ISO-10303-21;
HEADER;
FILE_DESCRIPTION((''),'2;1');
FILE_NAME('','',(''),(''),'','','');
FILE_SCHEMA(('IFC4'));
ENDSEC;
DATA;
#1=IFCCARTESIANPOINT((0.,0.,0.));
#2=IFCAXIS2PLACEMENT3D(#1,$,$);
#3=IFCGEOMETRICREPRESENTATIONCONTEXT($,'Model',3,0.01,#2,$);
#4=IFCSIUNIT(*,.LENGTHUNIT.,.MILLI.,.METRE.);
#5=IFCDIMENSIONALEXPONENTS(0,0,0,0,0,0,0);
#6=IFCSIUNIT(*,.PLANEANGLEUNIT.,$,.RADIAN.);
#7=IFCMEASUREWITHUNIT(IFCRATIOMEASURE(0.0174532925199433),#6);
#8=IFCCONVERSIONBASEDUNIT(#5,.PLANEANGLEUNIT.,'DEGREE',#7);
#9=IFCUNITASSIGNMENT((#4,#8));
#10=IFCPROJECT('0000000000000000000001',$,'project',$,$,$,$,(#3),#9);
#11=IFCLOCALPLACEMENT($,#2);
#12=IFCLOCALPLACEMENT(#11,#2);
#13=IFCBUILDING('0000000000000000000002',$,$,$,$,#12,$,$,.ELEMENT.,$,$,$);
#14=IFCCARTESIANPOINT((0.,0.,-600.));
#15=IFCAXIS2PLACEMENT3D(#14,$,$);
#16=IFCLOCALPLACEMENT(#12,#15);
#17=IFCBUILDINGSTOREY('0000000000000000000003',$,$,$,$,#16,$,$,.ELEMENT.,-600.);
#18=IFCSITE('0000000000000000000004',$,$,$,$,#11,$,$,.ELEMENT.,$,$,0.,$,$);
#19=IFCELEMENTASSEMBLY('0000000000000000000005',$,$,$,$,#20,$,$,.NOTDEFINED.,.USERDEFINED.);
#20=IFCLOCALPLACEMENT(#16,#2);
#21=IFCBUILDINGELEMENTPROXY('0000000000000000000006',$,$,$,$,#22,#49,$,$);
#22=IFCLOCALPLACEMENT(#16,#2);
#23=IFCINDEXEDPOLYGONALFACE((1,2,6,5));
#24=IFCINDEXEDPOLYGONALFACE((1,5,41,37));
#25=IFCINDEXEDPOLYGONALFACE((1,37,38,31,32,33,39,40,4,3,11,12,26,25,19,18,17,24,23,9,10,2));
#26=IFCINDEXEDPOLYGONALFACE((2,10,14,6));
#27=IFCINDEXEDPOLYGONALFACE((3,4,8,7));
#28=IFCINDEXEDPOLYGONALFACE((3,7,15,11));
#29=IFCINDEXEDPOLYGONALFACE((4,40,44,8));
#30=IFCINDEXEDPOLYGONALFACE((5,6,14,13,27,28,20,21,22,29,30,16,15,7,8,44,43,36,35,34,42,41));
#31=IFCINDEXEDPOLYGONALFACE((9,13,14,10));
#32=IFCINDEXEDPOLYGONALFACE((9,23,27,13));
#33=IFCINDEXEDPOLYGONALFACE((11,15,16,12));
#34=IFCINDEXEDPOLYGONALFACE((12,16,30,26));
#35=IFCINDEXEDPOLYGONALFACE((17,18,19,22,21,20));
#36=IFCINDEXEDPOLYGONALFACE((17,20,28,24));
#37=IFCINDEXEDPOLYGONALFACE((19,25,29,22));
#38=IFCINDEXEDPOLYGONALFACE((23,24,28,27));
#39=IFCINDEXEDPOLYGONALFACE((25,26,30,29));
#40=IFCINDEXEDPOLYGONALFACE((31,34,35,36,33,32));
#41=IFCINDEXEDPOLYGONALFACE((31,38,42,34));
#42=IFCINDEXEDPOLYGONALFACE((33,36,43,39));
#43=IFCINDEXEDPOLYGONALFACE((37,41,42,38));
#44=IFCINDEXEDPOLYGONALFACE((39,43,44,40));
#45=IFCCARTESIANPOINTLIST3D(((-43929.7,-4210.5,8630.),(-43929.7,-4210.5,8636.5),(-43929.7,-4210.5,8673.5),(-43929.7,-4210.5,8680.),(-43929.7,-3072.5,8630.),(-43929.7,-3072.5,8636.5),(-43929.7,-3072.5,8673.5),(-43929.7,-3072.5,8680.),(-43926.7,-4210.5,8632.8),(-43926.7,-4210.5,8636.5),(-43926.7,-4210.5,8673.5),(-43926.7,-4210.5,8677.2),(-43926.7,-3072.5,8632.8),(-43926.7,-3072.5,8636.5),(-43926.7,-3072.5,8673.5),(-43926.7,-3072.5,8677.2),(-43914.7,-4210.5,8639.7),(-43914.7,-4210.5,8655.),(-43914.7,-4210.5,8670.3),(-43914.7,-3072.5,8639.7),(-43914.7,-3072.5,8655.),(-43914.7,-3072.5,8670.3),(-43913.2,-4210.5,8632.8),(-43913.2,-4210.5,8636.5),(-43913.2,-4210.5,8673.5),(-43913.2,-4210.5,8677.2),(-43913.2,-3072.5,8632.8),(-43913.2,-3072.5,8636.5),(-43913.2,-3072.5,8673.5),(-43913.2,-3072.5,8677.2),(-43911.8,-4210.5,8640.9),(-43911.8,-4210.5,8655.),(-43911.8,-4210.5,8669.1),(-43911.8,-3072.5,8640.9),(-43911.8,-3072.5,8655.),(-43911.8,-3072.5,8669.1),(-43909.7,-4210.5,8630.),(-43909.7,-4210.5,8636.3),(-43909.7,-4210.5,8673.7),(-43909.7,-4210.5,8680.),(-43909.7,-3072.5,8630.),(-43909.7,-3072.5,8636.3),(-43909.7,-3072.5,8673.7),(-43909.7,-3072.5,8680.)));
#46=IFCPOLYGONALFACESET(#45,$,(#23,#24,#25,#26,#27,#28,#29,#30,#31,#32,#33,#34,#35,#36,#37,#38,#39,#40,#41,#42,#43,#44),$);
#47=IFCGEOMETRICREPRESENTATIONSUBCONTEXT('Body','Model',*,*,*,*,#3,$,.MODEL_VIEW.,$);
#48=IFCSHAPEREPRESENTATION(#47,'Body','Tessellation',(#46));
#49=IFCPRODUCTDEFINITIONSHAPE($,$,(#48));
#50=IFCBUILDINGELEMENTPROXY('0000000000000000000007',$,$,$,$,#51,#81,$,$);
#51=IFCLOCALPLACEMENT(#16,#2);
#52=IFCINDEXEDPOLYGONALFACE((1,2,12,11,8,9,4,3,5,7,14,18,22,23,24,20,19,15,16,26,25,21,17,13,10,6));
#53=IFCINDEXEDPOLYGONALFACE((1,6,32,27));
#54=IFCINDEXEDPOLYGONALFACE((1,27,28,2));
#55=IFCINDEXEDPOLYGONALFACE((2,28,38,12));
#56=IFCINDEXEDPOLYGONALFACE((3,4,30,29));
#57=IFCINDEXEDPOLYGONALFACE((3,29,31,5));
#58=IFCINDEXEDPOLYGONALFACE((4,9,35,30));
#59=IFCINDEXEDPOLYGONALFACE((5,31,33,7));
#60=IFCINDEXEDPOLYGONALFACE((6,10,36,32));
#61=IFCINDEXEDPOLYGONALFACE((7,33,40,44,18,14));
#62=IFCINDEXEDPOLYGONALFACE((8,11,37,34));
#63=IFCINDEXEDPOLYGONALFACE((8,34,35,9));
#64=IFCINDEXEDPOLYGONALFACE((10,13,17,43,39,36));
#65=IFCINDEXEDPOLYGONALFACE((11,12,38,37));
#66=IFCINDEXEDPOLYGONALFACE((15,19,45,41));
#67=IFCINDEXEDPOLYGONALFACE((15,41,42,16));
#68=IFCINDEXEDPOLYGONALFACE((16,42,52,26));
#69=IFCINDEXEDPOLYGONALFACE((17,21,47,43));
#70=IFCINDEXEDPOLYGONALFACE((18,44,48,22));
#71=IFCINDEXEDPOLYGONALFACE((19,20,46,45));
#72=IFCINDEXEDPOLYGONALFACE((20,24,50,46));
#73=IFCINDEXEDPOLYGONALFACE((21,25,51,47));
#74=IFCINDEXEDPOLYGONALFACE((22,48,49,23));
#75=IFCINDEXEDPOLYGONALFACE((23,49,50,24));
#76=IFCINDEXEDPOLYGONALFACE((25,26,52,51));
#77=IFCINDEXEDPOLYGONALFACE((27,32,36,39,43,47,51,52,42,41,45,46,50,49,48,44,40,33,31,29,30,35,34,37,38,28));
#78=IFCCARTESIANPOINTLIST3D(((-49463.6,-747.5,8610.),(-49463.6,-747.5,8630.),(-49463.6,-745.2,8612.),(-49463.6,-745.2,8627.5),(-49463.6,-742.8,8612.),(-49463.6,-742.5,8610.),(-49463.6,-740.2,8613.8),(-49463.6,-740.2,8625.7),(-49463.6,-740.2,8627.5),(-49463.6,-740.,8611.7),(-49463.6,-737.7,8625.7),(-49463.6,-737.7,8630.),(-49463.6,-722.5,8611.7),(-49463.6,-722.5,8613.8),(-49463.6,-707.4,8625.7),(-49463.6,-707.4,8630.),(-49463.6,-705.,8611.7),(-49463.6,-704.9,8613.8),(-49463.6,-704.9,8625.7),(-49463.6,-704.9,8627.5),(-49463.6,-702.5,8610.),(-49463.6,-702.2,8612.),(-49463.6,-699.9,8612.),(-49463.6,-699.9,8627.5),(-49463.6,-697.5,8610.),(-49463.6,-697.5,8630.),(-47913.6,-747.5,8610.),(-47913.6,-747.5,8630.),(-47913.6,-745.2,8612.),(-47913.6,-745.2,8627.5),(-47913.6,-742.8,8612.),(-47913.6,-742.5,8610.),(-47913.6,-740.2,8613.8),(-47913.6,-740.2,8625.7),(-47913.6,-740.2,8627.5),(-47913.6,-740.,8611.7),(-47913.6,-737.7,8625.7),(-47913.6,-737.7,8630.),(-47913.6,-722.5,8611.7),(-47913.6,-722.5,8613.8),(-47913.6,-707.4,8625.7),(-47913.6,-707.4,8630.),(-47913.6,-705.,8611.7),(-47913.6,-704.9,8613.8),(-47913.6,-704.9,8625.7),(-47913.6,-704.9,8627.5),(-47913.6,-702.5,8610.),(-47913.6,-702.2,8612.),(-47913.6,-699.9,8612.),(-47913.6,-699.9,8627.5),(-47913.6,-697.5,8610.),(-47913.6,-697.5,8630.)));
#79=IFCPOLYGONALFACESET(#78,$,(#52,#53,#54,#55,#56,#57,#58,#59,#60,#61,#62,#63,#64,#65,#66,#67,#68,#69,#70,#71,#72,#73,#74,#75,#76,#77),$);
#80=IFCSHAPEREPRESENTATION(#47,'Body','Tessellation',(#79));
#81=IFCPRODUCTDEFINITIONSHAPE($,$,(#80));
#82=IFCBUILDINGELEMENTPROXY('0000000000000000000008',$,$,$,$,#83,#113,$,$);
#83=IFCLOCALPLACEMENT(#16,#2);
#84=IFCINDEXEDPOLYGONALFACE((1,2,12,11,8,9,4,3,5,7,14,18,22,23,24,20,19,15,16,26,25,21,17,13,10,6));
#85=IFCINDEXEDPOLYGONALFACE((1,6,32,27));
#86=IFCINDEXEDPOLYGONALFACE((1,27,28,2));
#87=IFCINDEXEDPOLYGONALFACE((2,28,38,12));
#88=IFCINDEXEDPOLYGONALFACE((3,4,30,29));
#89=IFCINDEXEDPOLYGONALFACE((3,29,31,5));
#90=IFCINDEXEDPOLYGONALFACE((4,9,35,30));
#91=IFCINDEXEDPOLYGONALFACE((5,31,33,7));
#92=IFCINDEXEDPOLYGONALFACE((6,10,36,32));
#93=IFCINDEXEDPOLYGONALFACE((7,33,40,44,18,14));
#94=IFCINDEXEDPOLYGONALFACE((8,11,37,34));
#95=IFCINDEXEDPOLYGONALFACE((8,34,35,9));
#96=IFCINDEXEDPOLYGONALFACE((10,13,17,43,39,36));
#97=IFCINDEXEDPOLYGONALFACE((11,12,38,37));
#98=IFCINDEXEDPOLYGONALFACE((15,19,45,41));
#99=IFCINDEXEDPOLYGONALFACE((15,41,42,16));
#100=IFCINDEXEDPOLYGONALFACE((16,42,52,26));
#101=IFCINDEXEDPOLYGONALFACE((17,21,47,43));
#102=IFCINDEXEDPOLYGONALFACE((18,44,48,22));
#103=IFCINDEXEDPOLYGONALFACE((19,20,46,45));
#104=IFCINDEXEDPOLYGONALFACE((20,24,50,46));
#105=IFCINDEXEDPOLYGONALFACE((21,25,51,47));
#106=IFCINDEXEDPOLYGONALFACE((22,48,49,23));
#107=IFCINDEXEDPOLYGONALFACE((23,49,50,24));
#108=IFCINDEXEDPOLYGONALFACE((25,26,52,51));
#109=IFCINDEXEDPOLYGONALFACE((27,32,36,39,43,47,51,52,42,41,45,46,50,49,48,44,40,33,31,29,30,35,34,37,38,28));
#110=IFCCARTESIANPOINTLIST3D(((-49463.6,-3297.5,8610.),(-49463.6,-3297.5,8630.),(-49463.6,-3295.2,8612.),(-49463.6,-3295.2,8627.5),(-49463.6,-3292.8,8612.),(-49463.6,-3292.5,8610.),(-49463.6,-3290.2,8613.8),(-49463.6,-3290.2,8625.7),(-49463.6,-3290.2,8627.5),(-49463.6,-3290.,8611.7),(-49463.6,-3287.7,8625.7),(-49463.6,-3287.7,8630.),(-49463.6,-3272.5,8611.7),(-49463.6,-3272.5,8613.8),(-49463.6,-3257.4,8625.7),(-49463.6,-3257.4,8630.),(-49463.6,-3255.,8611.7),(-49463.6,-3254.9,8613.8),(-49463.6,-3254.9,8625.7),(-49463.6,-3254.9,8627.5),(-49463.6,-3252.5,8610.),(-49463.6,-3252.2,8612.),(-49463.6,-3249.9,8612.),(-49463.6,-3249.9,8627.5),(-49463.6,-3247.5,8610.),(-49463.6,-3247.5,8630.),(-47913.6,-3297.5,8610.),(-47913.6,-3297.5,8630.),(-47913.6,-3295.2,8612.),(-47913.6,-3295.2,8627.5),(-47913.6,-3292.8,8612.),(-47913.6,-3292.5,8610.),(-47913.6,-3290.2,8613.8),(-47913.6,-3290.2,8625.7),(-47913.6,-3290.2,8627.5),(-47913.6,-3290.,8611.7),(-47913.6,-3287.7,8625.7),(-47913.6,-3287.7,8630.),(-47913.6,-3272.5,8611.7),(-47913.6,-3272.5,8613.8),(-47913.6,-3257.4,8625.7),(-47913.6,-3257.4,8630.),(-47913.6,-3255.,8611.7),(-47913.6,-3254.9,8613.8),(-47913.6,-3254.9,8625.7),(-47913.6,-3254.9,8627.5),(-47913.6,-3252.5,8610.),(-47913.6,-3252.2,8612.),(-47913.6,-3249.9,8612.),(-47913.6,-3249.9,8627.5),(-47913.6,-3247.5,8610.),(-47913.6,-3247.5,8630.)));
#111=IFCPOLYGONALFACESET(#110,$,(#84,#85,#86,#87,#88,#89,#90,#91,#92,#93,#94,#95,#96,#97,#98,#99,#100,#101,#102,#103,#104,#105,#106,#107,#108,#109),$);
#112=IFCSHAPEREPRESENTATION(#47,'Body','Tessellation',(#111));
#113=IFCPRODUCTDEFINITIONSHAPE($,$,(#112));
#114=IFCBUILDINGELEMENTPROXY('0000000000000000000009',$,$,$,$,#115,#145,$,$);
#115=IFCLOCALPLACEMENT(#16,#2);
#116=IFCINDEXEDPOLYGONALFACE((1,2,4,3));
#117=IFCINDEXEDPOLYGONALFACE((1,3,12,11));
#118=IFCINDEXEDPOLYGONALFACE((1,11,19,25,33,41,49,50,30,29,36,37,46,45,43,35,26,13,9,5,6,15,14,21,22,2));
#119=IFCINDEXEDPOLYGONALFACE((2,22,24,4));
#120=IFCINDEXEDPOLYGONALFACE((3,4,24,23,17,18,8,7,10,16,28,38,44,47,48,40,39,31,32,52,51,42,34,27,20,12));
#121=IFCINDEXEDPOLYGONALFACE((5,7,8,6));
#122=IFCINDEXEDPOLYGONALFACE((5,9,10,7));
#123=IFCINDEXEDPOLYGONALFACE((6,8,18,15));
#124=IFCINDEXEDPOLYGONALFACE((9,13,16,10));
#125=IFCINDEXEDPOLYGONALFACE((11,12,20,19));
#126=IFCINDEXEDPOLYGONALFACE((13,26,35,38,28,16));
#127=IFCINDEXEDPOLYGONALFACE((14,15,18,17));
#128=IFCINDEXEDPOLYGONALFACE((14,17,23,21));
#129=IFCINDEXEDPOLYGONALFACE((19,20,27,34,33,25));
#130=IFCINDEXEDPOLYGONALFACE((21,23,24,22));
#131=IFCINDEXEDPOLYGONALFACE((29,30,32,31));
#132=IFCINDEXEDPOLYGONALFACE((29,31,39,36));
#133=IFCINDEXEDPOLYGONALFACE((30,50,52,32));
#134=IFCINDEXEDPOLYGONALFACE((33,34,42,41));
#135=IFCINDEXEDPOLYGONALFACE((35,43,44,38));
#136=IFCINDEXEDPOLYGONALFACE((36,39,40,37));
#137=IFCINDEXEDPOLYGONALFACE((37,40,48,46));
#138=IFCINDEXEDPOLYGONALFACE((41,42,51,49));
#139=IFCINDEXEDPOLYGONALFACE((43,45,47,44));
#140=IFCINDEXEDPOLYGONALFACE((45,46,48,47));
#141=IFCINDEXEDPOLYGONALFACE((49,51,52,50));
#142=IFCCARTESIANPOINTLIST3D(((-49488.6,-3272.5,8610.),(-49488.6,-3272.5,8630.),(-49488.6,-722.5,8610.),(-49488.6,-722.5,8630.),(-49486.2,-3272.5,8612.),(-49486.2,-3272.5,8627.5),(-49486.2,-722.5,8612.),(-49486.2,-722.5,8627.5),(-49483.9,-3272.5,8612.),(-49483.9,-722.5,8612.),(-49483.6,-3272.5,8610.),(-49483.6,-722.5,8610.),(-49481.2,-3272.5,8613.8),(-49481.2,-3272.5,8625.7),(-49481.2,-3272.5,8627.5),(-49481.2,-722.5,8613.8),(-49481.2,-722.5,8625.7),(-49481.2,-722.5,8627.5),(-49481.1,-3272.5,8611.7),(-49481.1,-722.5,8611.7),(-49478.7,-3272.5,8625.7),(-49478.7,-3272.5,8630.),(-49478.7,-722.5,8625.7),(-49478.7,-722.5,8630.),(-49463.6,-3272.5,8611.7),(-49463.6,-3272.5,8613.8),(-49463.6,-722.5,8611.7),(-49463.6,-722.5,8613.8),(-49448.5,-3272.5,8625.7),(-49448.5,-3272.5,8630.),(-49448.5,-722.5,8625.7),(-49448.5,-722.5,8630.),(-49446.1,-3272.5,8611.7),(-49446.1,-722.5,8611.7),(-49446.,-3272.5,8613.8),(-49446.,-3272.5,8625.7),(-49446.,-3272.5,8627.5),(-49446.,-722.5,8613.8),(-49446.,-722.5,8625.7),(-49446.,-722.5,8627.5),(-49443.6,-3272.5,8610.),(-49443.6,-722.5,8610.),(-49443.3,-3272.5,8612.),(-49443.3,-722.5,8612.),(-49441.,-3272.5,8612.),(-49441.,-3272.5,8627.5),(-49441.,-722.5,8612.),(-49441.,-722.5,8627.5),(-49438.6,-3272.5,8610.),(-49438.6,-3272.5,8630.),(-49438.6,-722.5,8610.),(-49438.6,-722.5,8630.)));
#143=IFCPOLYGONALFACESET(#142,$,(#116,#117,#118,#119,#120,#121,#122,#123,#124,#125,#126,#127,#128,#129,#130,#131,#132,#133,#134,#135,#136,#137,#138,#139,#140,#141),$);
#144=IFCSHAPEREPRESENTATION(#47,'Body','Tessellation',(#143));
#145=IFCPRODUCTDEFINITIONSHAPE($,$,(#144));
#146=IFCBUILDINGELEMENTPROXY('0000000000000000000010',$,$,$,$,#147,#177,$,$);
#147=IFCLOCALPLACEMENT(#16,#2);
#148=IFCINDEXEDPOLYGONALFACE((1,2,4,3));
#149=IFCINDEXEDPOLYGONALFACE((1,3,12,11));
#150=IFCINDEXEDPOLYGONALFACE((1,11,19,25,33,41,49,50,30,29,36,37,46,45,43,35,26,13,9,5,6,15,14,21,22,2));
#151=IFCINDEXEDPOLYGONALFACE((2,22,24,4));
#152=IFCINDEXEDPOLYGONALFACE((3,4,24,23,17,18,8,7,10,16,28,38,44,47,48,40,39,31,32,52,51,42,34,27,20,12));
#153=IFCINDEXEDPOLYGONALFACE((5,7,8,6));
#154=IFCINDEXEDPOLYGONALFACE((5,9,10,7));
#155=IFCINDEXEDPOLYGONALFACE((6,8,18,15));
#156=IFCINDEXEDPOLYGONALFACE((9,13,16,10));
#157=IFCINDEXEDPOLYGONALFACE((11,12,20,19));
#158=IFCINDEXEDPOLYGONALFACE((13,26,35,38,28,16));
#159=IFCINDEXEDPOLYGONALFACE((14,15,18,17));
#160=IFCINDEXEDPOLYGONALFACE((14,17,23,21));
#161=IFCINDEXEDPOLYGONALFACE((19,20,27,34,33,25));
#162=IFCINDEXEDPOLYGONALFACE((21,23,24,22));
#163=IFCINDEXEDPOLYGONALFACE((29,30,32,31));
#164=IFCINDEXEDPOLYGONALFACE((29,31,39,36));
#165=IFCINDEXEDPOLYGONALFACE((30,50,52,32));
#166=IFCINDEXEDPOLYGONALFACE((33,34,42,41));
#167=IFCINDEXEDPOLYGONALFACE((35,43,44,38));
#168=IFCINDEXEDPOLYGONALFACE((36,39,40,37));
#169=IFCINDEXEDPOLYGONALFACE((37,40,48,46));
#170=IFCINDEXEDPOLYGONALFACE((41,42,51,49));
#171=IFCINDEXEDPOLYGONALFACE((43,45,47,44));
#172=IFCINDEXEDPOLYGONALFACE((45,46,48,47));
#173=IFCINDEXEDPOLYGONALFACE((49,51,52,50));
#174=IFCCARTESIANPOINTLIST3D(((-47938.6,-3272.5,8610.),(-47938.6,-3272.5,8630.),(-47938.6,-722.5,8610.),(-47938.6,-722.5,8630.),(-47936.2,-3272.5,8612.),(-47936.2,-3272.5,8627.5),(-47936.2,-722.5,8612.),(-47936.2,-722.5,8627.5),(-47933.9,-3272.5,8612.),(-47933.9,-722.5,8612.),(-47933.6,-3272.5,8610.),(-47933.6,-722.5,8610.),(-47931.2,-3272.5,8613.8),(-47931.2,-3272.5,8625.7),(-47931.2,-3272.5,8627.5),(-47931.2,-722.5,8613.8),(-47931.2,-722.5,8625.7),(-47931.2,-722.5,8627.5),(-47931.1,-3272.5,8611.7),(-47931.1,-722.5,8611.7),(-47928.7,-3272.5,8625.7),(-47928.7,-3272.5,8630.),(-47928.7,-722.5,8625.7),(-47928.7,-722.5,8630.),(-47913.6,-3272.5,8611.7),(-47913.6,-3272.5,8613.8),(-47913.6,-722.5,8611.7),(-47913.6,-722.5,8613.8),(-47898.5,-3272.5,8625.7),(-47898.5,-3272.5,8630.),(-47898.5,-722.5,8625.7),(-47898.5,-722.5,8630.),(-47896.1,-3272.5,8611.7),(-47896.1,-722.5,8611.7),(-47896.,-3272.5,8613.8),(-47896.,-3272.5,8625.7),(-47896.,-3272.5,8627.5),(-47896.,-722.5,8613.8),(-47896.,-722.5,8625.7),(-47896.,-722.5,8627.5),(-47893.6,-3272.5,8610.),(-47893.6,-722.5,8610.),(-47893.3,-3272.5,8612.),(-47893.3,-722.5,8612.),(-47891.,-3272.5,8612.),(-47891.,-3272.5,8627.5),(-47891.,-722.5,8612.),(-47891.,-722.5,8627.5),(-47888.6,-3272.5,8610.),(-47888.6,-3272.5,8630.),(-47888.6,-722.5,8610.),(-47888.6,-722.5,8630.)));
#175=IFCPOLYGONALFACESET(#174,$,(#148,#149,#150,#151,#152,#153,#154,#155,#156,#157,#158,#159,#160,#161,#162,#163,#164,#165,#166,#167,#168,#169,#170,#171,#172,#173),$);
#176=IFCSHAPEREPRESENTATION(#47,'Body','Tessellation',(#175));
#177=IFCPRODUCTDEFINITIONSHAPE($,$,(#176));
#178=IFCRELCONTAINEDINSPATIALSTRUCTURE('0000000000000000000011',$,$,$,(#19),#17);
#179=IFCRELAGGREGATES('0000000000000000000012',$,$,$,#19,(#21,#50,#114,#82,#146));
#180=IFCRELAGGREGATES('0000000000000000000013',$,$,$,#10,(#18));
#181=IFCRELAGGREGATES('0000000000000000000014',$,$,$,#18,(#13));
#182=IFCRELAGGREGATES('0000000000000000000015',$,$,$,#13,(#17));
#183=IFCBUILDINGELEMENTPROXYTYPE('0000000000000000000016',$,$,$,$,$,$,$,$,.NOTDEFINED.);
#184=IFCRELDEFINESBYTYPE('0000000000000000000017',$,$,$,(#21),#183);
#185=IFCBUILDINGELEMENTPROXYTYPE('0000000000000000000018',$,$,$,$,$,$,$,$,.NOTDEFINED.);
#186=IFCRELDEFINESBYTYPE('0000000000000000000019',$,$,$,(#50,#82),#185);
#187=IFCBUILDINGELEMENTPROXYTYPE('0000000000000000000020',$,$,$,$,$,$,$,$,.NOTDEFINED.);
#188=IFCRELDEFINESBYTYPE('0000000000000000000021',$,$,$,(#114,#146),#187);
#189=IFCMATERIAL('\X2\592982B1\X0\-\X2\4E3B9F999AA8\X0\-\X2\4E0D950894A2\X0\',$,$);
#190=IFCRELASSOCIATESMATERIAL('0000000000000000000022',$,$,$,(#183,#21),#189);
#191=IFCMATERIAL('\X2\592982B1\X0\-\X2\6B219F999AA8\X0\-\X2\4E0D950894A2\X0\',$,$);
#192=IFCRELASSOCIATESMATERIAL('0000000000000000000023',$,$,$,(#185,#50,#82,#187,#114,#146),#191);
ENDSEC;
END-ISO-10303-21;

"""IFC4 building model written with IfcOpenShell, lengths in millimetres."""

from ifc_helpers import new_model, entity, si_unit, converted_unit, frame, origin, place, context, subcontext, project, spatial, polyline, outline, extrude, source, transform, mapped, material, type_object, type_shapes, element, aggregate, save


model = new_model("IFC4")

# Units and contexts
model_context = context("Model", 3, precision=0.01, world=origin())
body_context = subcontext(model_context, "Body", "Model", "MODEL_VIEW")
ifc_project = project(units=[si_unit("LENGTHUNIT", "METRE", prefix="MILLI"), converted_unit("PLANEANGLEUNIT", "DEGREE", entity("IfcRatioMeasure", 0.0174532925199433), si_unit("PLANEANGLEUNIT", "RADIAN"), dimensions=[0, 0, 0, 0, 0, 0, 0])], contexts=[model_context])

# Site, building, storey
site_placement = place(None, origin())
site = spatial("IfcSite", under=ifc_project, at=site_placement, CompositionType="ELEMENT", RefElevation=0.0)
building_placement = place(site_placement, origin())
building = spatial("IfcBuilding", under=site, at=building_placement, CompositionType="ELEMENT")
storey_placement = place(building_placement, frame((0.0, 0.0, -600.0)))
storey = spatial("IfcBuildingStorey", under=building, at=storey_placement, CompositionType="ELEMENT", Elevation=-600.0)

# Element assembly, building element proxies
assembly_1_placement = place(storey_placement, origin())
assembly_1 = element("IfcElementAssembly", 1, at=assembly_1_placement, inside=storey, AssemblyPlace="NOTDEFINED", PredefinedType="USERDEFINED")
ifc_material_1 = material(Name="天花-次龙骨-不锈钢")
ifc_material_2 = material(Name="天花-主龙骨-不锈钢")
building_element_proxy_type_1 = type_object("IfcBuildingElementProxyType", PredefinedType="NOTDEFINED", material=ifc_material_2)
shared_shape_1 = source(origin(), body_context, "Body", "SweptSolid", [
    extrude(outline(polyline([(-25.0, -11.7), (-18.5, -11.7), (-18.5, -8.7), (-22.2, -8.7), (-22.2, 4.8), (-18.5, 4.8), (-15.3, 3.3), (0.0, 3.3), (15.3, 3.3), (18.5, 4.8), (22.2, 4.8), (22.2, -8.7), (18.5, -8.7), (18.5, -11.7), (25.0, -11.7), (25.0, 8.3), (18.7, 8.3), (14.1, 6.2), (0.0, 6.2), (-14.1, 6.2), (-18.7, 8.3), (-25.0, 8.3), (-25.0, -11.7)])), frame((0.0, 1.7, 0.0), z_axis=(1.0, 0.0, 0.0), x_axis=(0.0, 0.0, -1.0)), (0.0, 0.0, 1.0), 1138.0),
])
type_shapes(building_element_proxy_type_1, [shared_shape_1])
proxy_1_placement = place(assembly_1_placement, frame((-43919.7, -3072.5, 8655.0), z_axis=(0.0, 0.0, 1.0), x_axis=(0.0, -1.0, 0.0)))
proxy_1 = element("IfcBuildingElementProxy", 2, at=proxy_1_placement, type_object=building_element_proxy_type_1, material=ifc_material_2, context=body_context, shape_type="MappedRepresentation", body=[
    mapped(shared_shape_1, transform((0.0, 0.0, 0.0), scale=1.0)),
])
building_element_proxy_type_2 = type_object("IfcBuildingElementProxyType", PredefinedType="NOTDEFINED", material=ifc_material_1)
shared_shape_2 = source(origin(), body_context, "Body", "SweptSolid", [
    extrude(outline(polyline([(-25.0, -9.1), (-20.0, -9.1), (-17.5, -7.4), (0.0, -7.4), (17.5, -7.4), (20.0, -9.1), (25.0, -9.1), (25.0, 10.9), (15.1, 10.9), (15.1, 6.6), (17.6, 6.6), (17.6, 8.4), (22.6, 8.4), (22.6, -7.1), (20.3, -7.1), (17.6, -5.3), (0.0, -5.3), (-17.6, -5.3), (-20.3, -7.1), (-22.6, -7.1), (-22.6, 8.4), (-17.6, 8.4), (-17.6, 6.6), (-15.1, 6.6), (-15.1, 10.9), (-25.0, 10.9), (-25.0, -9.1)])), frame((0.0, 0.0, -0.9), z_axis=(1.0, 0.0, 0.0), x_axis=(0.0, 1.0, 0.0)), (0.0, 0.0, 1.0), 1550.0),
])
type_shapes(building_element_proxy_type_2, [shared_shape_2])
proxy_2_placement = place(assembly_1_placement, frame((-49463.6, -722.5, 8620.0)))
proxy_2 = element("IfcBuildingElementProxy", 3, at=proxy_2_placement, type_object=building_element_proxy_type_2, material=ifc_material_1, context=body_context, shape_type="MappedRepresentation", body=[
    mapped(shared_shape_2, transform((0.0, 0.0, 0.0), scale=1.0)),
])
proxy_3_placement = place(assembly_1_placement, frame((-49463.6, -3272.5, 8620.0)))
proxy_3 = element("IfcBuildingElementProxy", 4, at=proxy_3_placement, type_object=building_element_proxy_type_2, material=ifc_material_1, context=body_context, shape_type="MappedRepresentation", body=[
    mapped(shared_shape_2, transform((0.0, 0.0, 0.0), scale=1.0)),
])
building_element_proxy_type_3 = type_object("IfcBuildingElementProxyType", PredefinedType="NOTDEFINED", material=ifc_material_1)
shared_shape_3 = source(origin(), body_context, "Body", "SweptSolid", [
    extrude(outline(polyline([(-25.0, -9.1), (-20.0, -9.1), (-17.5, -7.4), (0.0, -7.4), (17.5, -7.4), (20.0, -9.1), (25.0, -9.1), (25.0, 10.9), (15.1, 10.9), (15.1, 6.6), (17.6, 6.6), (17.6, 8.4), (22.6, 8.4), (22.6, -7.1), (20.3, -7.1), (17.6, -5.3), (0.0, -5.3), (-17.6, -5.3), (-20.3, -7.1), (-22.6, -7.1), (-22.6, 8.4), (-17.6, 8.4), (-17.6, 6.6), (-15.1, 6.6), (-15.1, 10.9), (-25.0, 10.9), (-25.0, -9.1)])), frame((0.0, 0.0, -0.9), z_axis=(1.0, 0.0, 0.0), x_axis=(0.0, 1.0, 0.0)), (0.0, 0.0, 1.0), 2550.0),
])
type_shapes(building_element_proxy_type_3, [shared_shape_3])
proxy_4_placement = place(assembly_1_placement, frame((-49463.6, -722.5, 8620.0), z_axis=(0.0, 0.0, 1.0), x_axis=(0.0, -1.0, 0.0)))
proxy_4 = element("IfcBuildingElementProxy", 5, at=proxy_4_placement, type_object=building_element_proxy_type_3, material=ifc_material_1, context=body_context, shape_type="MappedRepresentation", body=[
    mapped(shared_shape_3, transform((0.0, 0.0, 0.0), scale=1.0)),
])
proxy_5_placement = place(assembly_1_placement, frame((-47913.6, -722.5, 8620.0), z_axis=(0.0, 0.0, 1.0), x_axis=(0.0, -1.0, 0.0)))
proxy_5 = element("IfcBuildingElementProxy", 6, at=proxy_5_placement, type_object=building_element_proxy_type_3, material=ifc_material_1, context=body_context, shape_type="MappedRepresentation", body=[
    mapped(shared_shape_3, transform((0.0, 0.0, 0.0), scale=1.0)),
])
aggregate(assembly_1, [proxy_1, proxy_2, proxy_4, proxy_3, proxy_5])

save(model, "model.ifc")
